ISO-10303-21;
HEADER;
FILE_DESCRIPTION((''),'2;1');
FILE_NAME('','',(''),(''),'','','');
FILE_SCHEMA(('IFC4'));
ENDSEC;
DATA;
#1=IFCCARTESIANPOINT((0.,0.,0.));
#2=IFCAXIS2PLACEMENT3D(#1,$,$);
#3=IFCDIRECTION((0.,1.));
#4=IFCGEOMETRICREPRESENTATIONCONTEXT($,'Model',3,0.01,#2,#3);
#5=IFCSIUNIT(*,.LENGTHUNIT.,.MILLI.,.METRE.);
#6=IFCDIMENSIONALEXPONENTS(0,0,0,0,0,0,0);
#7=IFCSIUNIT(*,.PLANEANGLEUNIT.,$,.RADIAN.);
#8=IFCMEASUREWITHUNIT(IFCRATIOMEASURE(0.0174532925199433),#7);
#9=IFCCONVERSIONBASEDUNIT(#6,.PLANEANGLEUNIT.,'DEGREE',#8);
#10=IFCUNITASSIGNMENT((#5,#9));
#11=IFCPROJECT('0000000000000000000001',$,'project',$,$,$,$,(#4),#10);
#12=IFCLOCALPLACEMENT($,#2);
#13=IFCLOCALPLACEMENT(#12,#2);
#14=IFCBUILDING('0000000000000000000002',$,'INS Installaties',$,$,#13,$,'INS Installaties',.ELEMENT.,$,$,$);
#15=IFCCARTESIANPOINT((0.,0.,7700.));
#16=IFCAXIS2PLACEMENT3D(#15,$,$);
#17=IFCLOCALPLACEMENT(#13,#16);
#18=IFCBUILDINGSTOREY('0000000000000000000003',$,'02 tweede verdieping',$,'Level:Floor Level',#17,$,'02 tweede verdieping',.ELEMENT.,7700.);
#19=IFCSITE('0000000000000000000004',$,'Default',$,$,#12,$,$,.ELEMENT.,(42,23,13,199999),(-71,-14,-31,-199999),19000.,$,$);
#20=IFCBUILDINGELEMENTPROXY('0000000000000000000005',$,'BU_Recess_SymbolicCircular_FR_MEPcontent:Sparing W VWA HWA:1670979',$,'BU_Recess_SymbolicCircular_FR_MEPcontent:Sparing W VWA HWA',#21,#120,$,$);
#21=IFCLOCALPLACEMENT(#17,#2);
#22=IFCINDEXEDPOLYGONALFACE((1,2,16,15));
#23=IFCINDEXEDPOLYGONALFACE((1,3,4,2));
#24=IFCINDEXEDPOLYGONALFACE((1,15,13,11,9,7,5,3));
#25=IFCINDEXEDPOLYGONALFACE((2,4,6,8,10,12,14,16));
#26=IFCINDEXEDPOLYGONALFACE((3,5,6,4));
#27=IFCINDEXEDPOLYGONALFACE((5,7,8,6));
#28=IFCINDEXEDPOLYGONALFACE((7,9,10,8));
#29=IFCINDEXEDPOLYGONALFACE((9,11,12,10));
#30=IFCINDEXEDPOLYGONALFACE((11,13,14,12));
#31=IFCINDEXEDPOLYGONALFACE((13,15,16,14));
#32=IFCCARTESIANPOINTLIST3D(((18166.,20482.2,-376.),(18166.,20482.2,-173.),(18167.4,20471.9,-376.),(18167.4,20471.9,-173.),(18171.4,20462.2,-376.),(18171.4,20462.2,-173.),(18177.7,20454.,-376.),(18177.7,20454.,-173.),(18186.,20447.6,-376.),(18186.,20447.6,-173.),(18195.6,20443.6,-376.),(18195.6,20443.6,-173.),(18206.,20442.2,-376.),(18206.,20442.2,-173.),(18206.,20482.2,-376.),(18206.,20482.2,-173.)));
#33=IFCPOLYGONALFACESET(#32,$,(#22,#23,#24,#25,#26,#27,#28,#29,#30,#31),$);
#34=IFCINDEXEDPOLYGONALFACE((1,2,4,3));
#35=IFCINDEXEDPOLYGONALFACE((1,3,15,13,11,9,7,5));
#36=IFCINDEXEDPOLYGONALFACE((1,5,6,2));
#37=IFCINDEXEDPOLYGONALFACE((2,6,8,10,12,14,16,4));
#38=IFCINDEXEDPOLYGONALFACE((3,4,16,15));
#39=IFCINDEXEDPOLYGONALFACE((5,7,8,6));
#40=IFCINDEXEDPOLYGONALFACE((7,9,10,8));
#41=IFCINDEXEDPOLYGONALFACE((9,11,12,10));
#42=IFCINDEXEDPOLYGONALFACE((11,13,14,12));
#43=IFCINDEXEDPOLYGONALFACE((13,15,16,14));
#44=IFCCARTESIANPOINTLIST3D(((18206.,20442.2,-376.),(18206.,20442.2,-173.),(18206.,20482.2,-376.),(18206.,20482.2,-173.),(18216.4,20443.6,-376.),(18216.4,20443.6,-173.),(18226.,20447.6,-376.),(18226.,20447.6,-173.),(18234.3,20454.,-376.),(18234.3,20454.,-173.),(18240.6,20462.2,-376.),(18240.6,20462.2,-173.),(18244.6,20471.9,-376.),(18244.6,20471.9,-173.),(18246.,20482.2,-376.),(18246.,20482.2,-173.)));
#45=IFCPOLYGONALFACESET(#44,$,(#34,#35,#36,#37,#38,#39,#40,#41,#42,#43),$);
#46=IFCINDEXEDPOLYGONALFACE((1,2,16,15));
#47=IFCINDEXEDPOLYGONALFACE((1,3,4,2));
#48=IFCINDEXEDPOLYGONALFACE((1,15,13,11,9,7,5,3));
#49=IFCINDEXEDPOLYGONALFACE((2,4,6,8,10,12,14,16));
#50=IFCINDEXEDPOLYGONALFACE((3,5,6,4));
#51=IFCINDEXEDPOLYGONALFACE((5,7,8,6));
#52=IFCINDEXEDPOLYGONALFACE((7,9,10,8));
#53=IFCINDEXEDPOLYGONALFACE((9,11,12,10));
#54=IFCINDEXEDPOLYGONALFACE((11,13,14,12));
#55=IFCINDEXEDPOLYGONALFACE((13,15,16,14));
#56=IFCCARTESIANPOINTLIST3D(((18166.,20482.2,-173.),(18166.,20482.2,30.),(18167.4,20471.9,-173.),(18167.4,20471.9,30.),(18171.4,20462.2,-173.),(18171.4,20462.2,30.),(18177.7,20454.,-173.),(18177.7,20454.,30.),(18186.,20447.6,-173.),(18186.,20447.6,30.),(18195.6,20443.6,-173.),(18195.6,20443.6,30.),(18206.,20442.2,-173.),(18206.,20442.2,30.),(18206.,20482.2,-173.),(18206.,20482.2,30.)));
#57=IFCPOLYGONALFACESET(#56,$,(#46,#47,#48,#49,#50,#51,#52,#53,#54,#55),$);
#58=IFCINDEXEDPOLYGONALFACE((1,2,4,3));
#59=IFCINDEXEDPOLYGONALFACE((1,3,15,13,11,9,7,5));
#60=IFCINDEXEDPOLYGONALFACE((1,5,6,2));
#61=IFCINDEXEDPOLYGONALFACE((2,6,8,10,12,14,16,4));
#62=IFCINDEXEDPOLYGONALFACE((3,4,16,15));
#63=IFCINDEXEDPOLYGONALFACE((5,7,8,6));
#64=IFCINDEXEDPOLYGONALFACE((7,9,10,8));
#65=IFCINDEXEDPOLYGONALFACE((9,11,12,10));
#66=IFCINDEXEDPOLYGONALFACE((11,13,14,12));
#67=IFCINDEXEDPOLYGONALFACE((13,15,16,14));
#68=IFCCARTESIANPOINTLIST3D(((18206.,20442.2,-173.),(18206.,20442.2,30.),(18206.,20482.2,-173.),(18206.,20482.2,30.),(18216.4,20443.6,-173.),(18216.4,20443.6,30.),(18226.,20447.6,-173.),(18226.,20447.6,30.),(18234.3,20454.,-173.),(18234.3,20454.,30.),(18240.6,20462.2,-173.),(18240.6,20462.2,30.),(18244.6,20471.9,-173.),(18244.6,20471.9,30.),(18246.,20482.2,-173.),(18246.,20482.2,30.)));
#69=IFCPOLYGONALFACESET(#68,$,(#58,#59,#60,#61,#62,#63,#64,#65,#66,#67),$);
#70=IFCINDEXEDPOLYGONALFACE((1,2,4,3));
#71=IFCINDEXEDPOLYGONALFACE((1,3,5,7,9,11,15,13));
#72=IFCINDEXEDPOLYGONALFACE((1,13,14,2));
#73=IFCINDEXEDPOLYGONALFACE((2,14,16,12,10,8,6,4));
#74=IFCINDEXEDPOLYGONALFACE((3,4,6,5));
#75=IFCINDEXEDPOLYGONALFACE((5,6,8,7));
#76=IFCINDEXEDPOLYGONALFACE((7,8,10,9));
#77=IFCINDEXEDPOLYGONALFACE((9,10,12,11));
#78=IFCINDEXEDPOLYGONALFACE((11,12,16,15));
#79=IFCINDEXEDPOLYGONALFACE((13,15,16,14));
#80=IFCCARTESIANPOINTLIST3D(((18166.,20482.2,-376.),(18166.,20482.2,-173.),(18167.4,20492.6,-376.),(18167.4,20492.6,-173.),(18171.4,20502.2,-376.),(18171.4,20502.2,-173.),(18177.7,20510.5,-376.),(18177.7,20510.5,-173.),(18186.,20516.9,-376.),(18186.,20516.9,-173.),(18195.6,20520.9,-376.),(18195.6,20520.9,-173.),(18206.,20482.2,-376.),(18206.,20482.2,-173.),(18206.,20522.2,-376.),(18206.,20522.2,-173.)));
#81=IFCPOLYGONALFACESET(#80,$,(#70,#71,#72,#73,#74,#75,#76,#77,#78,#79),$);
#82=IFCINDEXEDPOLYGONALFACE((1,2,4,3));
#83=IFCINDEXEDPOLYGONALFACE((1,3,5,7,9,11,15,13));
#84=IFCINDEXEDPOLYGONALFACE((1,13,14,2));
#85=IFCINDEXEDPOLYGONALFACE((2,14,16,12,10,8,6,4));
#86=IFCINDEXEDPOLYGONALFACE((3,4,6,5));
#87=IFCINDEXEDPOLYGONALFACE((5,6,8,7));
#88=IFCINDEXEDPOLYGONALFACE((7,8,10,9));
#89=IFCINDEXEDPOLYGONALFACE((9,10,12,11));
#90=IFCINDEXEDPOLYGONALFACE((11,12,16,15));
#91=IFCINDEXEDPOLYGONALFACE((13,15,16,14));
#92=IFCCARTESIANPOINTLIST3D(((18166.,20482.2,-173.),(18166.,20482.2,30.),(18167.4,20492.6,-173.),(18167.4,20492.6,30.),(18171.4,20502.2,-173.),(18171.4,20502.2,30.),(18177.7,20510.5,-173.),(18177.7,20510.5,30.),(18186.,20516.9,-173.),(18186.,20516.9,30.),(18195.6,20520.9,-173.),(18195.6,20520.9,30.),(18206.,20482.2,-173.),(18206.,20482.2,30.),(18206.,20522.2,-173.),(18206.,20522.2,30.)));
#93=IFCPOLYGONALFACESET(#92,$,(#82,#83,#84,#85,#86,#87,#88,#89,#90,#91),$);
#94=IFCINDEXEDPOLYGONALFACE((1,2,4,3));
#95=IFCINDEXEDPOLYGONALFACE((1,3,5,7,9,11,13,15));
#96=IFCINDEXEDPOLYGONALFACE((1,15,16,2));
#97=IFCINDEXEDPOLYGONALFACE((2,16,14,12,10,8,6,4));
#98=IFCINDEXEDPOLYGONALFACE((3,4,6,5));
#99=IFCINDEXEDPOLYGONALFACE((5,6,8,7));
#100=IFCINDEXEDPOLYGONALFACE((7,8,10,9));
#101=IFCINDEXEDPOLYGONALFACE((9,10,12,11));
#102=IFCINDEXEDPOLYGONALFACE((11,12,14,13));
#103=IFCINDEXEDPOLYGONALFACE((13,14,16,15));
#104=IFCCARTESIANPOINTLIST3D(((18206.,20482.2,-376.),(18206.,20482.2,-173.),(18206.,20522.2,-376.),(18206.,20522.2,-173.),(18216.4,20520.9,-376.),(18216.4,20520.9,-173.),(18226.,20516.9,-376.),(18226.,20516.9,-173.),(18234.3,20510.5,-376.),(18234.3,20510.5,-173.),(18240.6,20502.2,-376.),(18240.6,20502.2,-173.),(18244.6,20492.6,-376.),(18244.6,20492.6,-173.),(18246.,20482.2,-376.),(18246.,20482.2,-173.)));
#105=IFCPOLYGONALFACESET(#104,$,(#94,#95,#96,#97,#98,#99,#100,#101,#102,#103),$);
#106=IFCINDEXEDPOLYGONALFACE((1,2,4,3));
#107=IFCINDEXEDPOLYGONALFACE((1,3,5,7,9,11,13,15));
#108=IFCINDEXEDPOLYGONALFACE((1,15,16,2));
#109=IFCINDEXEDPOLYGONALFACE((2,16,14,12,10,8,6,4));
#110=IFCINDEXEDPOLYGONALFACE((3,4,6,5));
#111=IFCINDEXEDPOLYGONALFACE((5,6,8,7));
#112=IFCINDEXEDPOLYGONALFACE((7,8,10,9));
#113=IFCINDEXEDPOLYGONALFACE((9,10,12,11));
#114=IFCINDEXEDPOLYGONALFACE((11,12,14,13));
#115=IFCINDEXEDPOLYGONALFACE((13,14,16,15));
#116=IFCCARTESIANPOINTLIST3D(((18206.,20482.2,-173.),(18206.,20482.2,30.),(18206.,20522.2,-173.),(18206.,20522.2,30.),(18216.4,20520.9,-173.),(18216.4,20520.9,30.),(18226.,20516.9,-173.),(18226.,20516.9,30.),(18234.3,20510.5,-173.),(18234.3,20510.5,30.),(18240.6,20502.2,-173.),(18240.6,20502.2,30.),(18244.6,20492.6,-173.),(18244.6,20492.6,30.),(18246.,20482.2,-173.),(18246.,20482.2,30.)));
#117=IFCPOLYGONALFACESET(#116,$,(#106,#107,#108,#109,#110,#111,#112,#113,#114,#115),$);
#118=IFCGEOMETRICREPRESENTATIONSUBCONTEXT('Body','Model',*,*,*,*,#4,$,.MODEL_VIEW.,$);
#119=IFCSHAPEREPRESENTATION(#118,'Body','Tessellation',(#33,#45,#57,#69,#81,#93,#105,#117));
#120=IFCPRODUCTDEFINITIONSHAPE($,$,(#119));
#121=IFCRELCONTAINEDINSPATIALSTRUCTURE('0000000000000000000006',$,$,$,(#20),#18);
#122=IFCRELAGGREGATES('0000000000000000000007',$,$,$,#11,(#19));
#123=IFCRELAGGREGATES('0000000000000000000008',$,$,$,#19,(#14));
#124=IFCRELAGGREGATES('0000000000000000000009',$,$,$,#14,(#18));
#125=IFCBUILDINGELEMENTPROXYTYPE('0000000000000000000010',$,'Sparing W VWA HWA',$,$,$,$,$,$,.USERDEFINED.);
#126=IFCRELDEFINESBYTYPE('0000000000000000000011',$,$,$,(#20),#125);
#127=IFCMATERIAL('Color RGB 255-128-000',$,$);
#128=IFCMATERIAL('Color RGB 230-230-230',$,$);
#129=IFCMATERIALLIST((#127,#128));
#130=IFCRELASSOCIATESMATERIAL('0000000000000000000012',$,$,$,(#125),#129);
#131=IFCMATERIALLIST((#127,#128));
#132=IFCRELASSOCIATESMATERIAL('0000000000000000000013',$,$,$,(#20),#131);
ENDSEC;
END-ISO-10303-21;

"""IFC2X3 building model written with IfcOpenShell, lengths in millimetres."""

from ifc_helpers import new_model, entity, si_unit, converted_unit, direction, frame, frame_2d, origin, place, context, subcontext, project, spatial, polyline, circle_curve, parameter, trimmed, segment, composite_curve, outline, extrude, source, transform, mapped, material, material_list, type_object, type_shapes, element, save


model = new_model("IFC2X3")

# Units and contexts
model_context = context("Model", 3, precision=0.01, world=origin(), true_north=direction((0.0, 1.0)))
body_context = subcontext(model_context, "Body", "Model", "MODEL_VIEW")
ifc_project = project(units=[si_unit("LENGTHUNIT", "METRE", prefix="MILLI"), converted_unit("PLANEANGLEUNIT", "DEGREE", entity("IfcRatioMeasure", 0.0174532925199433), si_unit("PLANEANGLEUNIT", "RADIAN"), dimensions=[0, 0, 0, 0, 0, 0, 0])], contexts=[model_context])

# Site, building, storey
site_placement = place(None, origin())
site = spatial("IfcSite", under=ifc_project, at=site_placement, Name="Default", CompositionType="ELEMENT", RefLatitude=(42, 23, 13, 199999), RefLongitude=(-71, -14, -31, -199999), RefElevation=19000.0)
building_placement = place(site_placement, origin())
building = spatial("IfcBuilding", under=site, at=building_placement, Name="INS Installaties", LongName="INS Installaties", CompositionType="ELEMENT")
storey_placement = place(building_placement, frame((0.0, 0.0, 7700.0)))
storey = spatial("IfcBuildingStorey", under=building, at=storey_placement, Name="02 tweede verdieping", ObjectType="Level:Floor Level", LongName="02 tweede verdieping", CompositionType="ELEMENT", Elevation=7700.0)

# Building element proxy
ifc_material_1 = material(Name="Color RGB 255-128-000")
ifc_material_2 = material(Name="Color RGB 230-230-230")
ifc_material_list_1 = material_list([ifc_material_1, ifc_material_2])
building_element_proxy_type_1 = type_object("IfcBuildingElementProxyType", Name="Sparing W VWA HWA", PredefinedType="USERDEFINED", material=ifc_material_list_1)
shared_shape_1 = source(origin(), body_context, "Body", "SweptSolid", [
    extrude(outline(composite_curve([segment(trimmed(circle_curve(frame_2d((13.3, 13.3), x_axis=(1.0, 0.0)), 40.0), [parameter(180.0)], [parameter(270.0)], True, "PARAMETER"), True, "CONTINUOUS"), segment(polyline([(13.3, -26.7), (13.3, 13.3)]), True, "CONTINUOUS"), segment(polyline([(13.3, 13.3), (-26.7, 13.3)]), True, "CONTINUOUS")], self_intersect=False)), frame((13.3, 13.3, -403.0), z_axis=(0.0, 0.0, 1.0), x_axis=(-1.0, 0.0, 0.0)), (0.0, 0.0, 1.0), 203.0),
    extrude(outline(composite_curve([segment(polyline([(-26.7, -13.3), (13.3, -13.3)]), True, "CONTINUOUS"), segment(polyline([(13.3, -13.3), (13.3, 26.7)]), True, "CONTINUOUS"), segment(trimmed(circle_curve(frame_2d((13.3, -13.3), x_axis=(1.0, 0.0)), 40.0), [parameter(90.0)], [parameter(180.0)], True, "PARAMETER"), True, "CONTINUOUS")], self_intersect=False)), frame((-13.3, 13.3, -403.0)), (0.0, 0.0, 1.0), 203.0),
    extrude(outline(composite_curve([segment(trimmed(circle_curve(frame_2d((13.3, 13.3), x_axis=(1.0, 0.0)), 40.0), [parameter(180.0)], [parameter(270.0)], True, "PARAMETER"), True, "CONTINUOUS"), segment(polyline([(13.3, -26.7), (13.3, 13.3)]), True, "CONTINUOUS"), segment(polyline([(13.3, 13.3), (-26.7, 13.3)]), True, "CONTINUOUS")], self_intersect=False)), frame((13.3, 13.3, -200.0), z_axis=(0.0, 0.0, 1.0), x_axis=(-1.0, 0.0, 0.0)), (0.0, 0.0, 1.0), 203.0),
    extrude(outline(composite_curve([segment(polyline([(-26.7, -13.3), (13.3, -13.3)]), True, "CONTINUOUS"), segment(polyline([(13.3, -13.3), (13.3, 26.7)]), True, "CONTINUOUS"), segment(trimmed(circle_curve(frame_2d((13.3, -13.3), x_axis=(1.0, 0.0)), 40.0), [parameter(90.0)], [parameter(180.0)], True, "PARAMETER"), True, "CONTINUOUS")], self_intersect=False)), frame((-13.3, 13.3, -200.0)), (0.0, 0.0, 1.0), 203.0),
    extrude(outline(composite_curve([segment(polyline([(-26.7, -13.3), (13.3, -13.3)]), True, "CONTINUOUS"), segment(polyline([(13.3, -13.3), (13.3, 26.7)]), True, "CONTINUOUS"), segment(trimmed(circle_curve(frame_2d((13.3, -13.3), x_axis=(1.0, 0.0)), 40.0), [parameter(90.0)], [parameter(180.0)], True, "PARAMETER"), True, "CONTINUOUS")], self_intersect=False)), frame((13.3, -13.3, -403.0), z_axis=(0.0, 0.0, 1.0), x_axis=(-1.0, 0.0, 0.0)), (0.0, 0.0, 1.0), 203.0),
    extrude(outline(composite_curve([segment(polyline([(-26.7, -13.3), (13.3, -13.3)]), True, "CONTINUOUS"), segment(polyline([(13.3, -13.3), (13.3, 26.7)]), True, "CONTINUOUS"), segment(trimmed(circle_curve(frame_2d((13.3, -13.3), x_axis=(1.0, 0.0)), 40.0), [parameter(90.0)], [parameter(180.0)], True, "PARAMETER"), True, "CONTINUOUS")], self_intersect=False)), frame((13.3, -13.3, -200.0), z_axis=(0.0, 0.0, 1.0), x_axis=(-1.0, 0.0, 0.0)), (0.0, 0.0, 1.0), 203.0),
    extrude(outline(composite_curve([segment(trimmed(circle_curve(frame_2d((13.3, 13.3), x_axis=(1.0, 0.0)), 40.0), [parameter(180.0)], [parameter(270.0)], True, "PARAMETER"), True, "CONTINUOUS"), segment(polyline([(13.3, -26.7), (13.3, 13.3)]), True, "CONTINUOUS"), segment(polyline([(13.3, 13.3), (-26.7, 13.3)]), True, "CONTINUOUS")], self_intersect=False)), frame((-13.3, -13.3, -403.0)), (0.0, 0.0, 1.0), 203.0),
    extrude(outline(composite_curve([segment(trimmed(circle_curve(frame_2d((13.3, 13.3), x_axis=(1.0, 0.0)), 40.0), [parameter(180.0)], [parameter(270.0)], True, "PARAMETER"), True, "CONTINUOUS"), segment(polyline([(13.3, -26.7), (13.3, 13.3)]), True, "CONTINUOUS"), segment(polyline([(13.3, 13.3), (-26.7, 13.3)]), True, "CONTINUOUS")], self_intersect=False)), frame((-13.3, -13.3, -200.0)), (0.0, 0.0, 1.0), 203.0),
])
type_shapes(building_element_proxy_type_1, [shared_shape_1])
ifc_material_list_2 = material_list([ifc_material_1, ifc_material_2])
proxy_1_placement = place(storey_placement, frame((18206.0, 20482.2, 27.0), z_axis=(0.0, 0.0, 1.0), x_axis=(-1.0, 0.0, 0.0)))
element("IfcBuildingElementProxy", 1, at=proxy_1_placement, inside=storey, type_object=building_element_proxy_type_1, material=ifc_material_list_2, Name="BU_Recess_SymbolicCircular_FR_MEPcontent:Sparing W VWA HWA:1670979", ObjectType="BU_Recess_SymbolicCircular_FR_MEPcontent:Sparing W VWA HWA", context=body_context, shape_type="MappedRepresentation", body=[
    mapped(shared_shape_1, transform((0.0, 0.0, 0.0), scale=1.0)),
])

save(model, "model.ifc")
